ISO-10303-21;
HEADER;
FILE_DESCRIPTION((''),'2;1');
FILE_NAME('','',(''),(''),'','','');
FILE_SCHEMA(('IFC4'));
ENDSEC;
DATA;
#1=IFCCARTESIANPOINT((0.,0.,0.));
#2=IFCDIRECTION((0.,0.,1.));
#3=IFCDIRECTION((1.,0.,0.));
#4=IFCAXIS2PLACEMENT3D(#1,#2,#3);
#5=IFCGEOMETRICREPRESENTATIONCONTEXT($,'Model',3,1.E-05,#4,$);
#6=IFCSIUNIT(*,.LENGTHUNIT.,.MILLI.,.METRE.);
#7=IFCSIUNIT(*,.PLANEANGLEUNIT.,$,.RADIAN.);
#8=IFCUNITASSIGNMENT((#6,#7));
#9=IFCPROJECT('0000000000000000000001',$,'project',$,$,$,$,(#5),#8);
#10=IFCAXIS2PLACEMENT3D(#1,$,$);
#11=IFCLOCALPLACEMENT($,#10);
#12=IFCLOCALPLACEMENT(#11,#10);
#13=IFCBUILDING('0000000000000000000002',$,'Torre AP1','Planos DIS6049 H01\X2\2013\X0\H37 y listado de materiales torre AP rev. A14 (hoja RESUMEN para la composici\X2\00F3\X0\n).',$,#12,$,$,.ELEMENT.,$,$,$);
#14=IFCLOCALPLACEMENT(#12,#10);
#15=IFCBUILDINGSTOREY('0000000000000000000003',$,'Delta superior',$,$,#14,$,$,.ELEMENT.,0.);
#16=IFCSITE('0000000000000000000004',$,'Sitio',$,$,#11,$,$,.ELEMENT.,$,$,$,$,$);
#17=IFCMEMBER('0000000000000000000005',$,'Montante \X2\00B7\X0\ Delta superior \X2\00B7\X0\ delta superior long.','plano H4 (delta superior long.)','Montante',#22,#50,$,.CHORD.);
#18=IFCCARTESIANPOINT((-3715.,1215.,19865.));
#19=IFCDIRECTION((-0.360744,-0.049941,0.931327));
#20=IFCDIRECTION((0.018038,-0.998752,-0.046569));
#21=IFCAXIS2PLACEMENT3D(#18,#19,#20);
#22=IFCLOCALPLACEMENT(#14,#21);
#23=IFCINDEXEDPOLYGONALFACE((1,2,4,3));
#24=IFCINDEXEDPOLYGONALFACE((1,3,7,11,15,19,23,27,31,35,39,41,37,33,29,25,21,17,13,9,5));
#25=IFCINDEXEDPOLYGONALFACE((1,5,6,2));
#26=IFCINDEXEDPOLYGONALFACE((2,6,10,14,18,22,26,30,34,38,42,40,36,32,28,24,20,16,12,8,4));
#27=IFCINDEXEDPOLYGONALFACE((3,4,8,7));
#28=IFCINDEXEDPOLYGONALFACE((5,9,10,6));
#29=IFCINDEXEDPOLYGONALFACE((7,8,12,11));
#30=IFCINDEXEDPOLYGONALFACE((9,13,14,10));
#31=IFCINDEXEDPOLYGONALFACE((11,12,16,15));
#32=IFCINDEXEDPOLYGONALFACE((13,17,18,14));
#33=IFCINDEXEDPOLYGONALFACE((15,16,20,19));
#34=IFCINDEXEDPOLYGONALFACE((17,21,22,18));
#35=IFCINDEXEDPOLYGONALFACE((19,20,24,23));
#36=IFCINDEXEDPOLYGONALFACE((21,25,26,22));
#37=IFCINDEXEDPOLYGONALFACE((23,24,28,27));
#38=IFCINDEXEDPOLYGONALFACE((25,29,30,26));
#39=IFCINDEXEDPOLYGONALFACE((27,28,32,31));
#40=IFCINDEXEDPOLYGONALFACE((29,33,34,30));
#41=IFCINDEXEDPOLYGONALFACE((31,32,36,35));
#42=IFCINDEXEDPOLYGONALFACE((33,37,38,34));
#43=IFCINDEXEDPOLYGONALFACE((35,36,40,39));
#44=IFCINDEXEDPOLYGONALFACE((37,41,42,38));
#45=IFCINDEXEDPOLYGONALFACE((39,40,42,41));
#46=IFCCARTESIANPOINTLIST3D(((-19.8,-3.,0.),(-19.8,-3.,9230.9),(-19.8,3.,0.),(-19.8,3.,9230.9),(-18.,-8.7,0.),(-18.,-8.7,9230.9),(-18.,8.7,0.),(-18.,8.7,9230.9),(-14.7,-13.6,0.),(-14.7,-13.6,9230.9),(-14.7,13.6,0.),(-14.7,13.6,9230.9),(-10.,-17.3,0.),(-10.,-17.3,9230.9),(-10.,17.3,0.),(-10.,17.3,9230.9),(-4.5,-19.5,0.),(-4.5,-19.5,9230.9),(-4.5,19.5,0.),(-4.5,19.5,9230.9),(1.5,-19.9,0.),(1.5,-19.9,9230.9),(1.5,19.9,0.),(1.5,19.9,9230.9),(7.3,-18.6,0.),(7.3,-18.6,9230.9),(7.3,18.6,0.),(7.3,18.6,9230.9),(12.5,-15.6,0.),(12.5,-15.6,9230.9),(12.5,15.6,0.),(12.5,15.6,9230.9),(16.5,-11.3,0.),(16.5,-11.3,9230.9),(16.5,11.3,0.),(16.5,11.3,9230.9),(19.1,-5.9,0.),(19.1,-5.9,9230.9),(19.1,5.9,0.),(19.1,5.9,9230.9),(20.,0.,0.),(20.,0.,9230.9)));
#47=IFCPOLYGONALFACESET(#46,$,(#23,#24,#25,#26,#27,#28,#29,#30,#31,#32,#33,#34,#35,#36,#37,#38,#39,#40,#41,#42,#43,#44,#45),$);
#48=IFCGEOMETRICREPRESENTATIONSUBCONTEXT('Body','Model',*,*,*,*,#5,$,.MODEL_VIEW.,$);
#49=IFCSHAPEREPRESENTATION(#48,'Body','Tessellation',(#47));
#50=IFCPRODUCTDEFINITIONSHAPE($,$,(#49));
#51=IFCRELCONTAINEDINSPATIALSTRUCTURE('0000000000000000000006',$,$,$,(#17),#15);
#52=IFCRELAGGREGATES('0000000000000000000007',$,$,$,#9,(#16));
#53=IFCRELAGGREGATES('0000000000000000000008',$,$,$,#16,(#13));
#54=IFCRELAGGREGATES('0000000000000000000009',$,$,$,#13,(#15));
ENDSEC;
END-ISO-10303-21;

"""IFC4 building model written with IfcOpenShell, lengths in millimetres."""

from ifc_helpers import new_model, si_unit, frame, origin, origin_with_axes, place, context, subcontext, project, spatial, circle, extrude, element, save


model = new_model("IFC4")

# Units and contexts
model_context = context("Model", 3, precision=1e-05, world=origin_with_axes())
body_context = subcontext(model_context, "Body", "Model", "MODEL_VIEW")
ifc_project = project(units=[si_unit("LENGTHUNIT", "METRE", prefix="MILLI"), si_unit("PLANEANGLEUNIT", "RADIAN")], contexts=[model_context])

# Site, building, storey
site_placement = place(None, origin())
site = spatial("IfcSite", under=ifc_project, at=site_placement, Name="Sitio", CompositionType="ELEMENT")
building_placement = place(site_placement, origin())
building = spatial("IfcBuilding", under=site, at=building_placement, Name="Torre AP1", Description="Planos DIS6049 H01–H37 y listado de materiales torre AP rev. A14 (hoja RESUMEN para la composición).", CompositionType="ELEMENT")
storey_placement = place(building_placement, origin())
storey = spatial("IfcBuildingStorey", under=building, at=storey_placement, Name="Delta superior", CompositionType="ELEMENT", Elevation=0.0)

# Member
for number, where, z_axis, x_axis, name in (
    (1, (-3715.0, 1215.0, 19865.0), (-0.360744, -0.049941, 0.931327), (0.018038, -0.998752, -0.046569), "Montante · Delta superior · delta superior long."),
):
    element("IfcMember", number, at=place(storey_placement, frame(where, z_axis=z_axis, x_axis=x_axis)), inside=storey, Name=name, Description="plano H4 (delta superior long.)", ObjectType="Montante", PredefinedType="CHORD", context=body_context, shape_type="SweptSolid", body=[
        extrude(circle(Radius=20.0), None, (0.0, 0.0, 1.0), 9230.9),
    ])

save(model, "model.ifc")
